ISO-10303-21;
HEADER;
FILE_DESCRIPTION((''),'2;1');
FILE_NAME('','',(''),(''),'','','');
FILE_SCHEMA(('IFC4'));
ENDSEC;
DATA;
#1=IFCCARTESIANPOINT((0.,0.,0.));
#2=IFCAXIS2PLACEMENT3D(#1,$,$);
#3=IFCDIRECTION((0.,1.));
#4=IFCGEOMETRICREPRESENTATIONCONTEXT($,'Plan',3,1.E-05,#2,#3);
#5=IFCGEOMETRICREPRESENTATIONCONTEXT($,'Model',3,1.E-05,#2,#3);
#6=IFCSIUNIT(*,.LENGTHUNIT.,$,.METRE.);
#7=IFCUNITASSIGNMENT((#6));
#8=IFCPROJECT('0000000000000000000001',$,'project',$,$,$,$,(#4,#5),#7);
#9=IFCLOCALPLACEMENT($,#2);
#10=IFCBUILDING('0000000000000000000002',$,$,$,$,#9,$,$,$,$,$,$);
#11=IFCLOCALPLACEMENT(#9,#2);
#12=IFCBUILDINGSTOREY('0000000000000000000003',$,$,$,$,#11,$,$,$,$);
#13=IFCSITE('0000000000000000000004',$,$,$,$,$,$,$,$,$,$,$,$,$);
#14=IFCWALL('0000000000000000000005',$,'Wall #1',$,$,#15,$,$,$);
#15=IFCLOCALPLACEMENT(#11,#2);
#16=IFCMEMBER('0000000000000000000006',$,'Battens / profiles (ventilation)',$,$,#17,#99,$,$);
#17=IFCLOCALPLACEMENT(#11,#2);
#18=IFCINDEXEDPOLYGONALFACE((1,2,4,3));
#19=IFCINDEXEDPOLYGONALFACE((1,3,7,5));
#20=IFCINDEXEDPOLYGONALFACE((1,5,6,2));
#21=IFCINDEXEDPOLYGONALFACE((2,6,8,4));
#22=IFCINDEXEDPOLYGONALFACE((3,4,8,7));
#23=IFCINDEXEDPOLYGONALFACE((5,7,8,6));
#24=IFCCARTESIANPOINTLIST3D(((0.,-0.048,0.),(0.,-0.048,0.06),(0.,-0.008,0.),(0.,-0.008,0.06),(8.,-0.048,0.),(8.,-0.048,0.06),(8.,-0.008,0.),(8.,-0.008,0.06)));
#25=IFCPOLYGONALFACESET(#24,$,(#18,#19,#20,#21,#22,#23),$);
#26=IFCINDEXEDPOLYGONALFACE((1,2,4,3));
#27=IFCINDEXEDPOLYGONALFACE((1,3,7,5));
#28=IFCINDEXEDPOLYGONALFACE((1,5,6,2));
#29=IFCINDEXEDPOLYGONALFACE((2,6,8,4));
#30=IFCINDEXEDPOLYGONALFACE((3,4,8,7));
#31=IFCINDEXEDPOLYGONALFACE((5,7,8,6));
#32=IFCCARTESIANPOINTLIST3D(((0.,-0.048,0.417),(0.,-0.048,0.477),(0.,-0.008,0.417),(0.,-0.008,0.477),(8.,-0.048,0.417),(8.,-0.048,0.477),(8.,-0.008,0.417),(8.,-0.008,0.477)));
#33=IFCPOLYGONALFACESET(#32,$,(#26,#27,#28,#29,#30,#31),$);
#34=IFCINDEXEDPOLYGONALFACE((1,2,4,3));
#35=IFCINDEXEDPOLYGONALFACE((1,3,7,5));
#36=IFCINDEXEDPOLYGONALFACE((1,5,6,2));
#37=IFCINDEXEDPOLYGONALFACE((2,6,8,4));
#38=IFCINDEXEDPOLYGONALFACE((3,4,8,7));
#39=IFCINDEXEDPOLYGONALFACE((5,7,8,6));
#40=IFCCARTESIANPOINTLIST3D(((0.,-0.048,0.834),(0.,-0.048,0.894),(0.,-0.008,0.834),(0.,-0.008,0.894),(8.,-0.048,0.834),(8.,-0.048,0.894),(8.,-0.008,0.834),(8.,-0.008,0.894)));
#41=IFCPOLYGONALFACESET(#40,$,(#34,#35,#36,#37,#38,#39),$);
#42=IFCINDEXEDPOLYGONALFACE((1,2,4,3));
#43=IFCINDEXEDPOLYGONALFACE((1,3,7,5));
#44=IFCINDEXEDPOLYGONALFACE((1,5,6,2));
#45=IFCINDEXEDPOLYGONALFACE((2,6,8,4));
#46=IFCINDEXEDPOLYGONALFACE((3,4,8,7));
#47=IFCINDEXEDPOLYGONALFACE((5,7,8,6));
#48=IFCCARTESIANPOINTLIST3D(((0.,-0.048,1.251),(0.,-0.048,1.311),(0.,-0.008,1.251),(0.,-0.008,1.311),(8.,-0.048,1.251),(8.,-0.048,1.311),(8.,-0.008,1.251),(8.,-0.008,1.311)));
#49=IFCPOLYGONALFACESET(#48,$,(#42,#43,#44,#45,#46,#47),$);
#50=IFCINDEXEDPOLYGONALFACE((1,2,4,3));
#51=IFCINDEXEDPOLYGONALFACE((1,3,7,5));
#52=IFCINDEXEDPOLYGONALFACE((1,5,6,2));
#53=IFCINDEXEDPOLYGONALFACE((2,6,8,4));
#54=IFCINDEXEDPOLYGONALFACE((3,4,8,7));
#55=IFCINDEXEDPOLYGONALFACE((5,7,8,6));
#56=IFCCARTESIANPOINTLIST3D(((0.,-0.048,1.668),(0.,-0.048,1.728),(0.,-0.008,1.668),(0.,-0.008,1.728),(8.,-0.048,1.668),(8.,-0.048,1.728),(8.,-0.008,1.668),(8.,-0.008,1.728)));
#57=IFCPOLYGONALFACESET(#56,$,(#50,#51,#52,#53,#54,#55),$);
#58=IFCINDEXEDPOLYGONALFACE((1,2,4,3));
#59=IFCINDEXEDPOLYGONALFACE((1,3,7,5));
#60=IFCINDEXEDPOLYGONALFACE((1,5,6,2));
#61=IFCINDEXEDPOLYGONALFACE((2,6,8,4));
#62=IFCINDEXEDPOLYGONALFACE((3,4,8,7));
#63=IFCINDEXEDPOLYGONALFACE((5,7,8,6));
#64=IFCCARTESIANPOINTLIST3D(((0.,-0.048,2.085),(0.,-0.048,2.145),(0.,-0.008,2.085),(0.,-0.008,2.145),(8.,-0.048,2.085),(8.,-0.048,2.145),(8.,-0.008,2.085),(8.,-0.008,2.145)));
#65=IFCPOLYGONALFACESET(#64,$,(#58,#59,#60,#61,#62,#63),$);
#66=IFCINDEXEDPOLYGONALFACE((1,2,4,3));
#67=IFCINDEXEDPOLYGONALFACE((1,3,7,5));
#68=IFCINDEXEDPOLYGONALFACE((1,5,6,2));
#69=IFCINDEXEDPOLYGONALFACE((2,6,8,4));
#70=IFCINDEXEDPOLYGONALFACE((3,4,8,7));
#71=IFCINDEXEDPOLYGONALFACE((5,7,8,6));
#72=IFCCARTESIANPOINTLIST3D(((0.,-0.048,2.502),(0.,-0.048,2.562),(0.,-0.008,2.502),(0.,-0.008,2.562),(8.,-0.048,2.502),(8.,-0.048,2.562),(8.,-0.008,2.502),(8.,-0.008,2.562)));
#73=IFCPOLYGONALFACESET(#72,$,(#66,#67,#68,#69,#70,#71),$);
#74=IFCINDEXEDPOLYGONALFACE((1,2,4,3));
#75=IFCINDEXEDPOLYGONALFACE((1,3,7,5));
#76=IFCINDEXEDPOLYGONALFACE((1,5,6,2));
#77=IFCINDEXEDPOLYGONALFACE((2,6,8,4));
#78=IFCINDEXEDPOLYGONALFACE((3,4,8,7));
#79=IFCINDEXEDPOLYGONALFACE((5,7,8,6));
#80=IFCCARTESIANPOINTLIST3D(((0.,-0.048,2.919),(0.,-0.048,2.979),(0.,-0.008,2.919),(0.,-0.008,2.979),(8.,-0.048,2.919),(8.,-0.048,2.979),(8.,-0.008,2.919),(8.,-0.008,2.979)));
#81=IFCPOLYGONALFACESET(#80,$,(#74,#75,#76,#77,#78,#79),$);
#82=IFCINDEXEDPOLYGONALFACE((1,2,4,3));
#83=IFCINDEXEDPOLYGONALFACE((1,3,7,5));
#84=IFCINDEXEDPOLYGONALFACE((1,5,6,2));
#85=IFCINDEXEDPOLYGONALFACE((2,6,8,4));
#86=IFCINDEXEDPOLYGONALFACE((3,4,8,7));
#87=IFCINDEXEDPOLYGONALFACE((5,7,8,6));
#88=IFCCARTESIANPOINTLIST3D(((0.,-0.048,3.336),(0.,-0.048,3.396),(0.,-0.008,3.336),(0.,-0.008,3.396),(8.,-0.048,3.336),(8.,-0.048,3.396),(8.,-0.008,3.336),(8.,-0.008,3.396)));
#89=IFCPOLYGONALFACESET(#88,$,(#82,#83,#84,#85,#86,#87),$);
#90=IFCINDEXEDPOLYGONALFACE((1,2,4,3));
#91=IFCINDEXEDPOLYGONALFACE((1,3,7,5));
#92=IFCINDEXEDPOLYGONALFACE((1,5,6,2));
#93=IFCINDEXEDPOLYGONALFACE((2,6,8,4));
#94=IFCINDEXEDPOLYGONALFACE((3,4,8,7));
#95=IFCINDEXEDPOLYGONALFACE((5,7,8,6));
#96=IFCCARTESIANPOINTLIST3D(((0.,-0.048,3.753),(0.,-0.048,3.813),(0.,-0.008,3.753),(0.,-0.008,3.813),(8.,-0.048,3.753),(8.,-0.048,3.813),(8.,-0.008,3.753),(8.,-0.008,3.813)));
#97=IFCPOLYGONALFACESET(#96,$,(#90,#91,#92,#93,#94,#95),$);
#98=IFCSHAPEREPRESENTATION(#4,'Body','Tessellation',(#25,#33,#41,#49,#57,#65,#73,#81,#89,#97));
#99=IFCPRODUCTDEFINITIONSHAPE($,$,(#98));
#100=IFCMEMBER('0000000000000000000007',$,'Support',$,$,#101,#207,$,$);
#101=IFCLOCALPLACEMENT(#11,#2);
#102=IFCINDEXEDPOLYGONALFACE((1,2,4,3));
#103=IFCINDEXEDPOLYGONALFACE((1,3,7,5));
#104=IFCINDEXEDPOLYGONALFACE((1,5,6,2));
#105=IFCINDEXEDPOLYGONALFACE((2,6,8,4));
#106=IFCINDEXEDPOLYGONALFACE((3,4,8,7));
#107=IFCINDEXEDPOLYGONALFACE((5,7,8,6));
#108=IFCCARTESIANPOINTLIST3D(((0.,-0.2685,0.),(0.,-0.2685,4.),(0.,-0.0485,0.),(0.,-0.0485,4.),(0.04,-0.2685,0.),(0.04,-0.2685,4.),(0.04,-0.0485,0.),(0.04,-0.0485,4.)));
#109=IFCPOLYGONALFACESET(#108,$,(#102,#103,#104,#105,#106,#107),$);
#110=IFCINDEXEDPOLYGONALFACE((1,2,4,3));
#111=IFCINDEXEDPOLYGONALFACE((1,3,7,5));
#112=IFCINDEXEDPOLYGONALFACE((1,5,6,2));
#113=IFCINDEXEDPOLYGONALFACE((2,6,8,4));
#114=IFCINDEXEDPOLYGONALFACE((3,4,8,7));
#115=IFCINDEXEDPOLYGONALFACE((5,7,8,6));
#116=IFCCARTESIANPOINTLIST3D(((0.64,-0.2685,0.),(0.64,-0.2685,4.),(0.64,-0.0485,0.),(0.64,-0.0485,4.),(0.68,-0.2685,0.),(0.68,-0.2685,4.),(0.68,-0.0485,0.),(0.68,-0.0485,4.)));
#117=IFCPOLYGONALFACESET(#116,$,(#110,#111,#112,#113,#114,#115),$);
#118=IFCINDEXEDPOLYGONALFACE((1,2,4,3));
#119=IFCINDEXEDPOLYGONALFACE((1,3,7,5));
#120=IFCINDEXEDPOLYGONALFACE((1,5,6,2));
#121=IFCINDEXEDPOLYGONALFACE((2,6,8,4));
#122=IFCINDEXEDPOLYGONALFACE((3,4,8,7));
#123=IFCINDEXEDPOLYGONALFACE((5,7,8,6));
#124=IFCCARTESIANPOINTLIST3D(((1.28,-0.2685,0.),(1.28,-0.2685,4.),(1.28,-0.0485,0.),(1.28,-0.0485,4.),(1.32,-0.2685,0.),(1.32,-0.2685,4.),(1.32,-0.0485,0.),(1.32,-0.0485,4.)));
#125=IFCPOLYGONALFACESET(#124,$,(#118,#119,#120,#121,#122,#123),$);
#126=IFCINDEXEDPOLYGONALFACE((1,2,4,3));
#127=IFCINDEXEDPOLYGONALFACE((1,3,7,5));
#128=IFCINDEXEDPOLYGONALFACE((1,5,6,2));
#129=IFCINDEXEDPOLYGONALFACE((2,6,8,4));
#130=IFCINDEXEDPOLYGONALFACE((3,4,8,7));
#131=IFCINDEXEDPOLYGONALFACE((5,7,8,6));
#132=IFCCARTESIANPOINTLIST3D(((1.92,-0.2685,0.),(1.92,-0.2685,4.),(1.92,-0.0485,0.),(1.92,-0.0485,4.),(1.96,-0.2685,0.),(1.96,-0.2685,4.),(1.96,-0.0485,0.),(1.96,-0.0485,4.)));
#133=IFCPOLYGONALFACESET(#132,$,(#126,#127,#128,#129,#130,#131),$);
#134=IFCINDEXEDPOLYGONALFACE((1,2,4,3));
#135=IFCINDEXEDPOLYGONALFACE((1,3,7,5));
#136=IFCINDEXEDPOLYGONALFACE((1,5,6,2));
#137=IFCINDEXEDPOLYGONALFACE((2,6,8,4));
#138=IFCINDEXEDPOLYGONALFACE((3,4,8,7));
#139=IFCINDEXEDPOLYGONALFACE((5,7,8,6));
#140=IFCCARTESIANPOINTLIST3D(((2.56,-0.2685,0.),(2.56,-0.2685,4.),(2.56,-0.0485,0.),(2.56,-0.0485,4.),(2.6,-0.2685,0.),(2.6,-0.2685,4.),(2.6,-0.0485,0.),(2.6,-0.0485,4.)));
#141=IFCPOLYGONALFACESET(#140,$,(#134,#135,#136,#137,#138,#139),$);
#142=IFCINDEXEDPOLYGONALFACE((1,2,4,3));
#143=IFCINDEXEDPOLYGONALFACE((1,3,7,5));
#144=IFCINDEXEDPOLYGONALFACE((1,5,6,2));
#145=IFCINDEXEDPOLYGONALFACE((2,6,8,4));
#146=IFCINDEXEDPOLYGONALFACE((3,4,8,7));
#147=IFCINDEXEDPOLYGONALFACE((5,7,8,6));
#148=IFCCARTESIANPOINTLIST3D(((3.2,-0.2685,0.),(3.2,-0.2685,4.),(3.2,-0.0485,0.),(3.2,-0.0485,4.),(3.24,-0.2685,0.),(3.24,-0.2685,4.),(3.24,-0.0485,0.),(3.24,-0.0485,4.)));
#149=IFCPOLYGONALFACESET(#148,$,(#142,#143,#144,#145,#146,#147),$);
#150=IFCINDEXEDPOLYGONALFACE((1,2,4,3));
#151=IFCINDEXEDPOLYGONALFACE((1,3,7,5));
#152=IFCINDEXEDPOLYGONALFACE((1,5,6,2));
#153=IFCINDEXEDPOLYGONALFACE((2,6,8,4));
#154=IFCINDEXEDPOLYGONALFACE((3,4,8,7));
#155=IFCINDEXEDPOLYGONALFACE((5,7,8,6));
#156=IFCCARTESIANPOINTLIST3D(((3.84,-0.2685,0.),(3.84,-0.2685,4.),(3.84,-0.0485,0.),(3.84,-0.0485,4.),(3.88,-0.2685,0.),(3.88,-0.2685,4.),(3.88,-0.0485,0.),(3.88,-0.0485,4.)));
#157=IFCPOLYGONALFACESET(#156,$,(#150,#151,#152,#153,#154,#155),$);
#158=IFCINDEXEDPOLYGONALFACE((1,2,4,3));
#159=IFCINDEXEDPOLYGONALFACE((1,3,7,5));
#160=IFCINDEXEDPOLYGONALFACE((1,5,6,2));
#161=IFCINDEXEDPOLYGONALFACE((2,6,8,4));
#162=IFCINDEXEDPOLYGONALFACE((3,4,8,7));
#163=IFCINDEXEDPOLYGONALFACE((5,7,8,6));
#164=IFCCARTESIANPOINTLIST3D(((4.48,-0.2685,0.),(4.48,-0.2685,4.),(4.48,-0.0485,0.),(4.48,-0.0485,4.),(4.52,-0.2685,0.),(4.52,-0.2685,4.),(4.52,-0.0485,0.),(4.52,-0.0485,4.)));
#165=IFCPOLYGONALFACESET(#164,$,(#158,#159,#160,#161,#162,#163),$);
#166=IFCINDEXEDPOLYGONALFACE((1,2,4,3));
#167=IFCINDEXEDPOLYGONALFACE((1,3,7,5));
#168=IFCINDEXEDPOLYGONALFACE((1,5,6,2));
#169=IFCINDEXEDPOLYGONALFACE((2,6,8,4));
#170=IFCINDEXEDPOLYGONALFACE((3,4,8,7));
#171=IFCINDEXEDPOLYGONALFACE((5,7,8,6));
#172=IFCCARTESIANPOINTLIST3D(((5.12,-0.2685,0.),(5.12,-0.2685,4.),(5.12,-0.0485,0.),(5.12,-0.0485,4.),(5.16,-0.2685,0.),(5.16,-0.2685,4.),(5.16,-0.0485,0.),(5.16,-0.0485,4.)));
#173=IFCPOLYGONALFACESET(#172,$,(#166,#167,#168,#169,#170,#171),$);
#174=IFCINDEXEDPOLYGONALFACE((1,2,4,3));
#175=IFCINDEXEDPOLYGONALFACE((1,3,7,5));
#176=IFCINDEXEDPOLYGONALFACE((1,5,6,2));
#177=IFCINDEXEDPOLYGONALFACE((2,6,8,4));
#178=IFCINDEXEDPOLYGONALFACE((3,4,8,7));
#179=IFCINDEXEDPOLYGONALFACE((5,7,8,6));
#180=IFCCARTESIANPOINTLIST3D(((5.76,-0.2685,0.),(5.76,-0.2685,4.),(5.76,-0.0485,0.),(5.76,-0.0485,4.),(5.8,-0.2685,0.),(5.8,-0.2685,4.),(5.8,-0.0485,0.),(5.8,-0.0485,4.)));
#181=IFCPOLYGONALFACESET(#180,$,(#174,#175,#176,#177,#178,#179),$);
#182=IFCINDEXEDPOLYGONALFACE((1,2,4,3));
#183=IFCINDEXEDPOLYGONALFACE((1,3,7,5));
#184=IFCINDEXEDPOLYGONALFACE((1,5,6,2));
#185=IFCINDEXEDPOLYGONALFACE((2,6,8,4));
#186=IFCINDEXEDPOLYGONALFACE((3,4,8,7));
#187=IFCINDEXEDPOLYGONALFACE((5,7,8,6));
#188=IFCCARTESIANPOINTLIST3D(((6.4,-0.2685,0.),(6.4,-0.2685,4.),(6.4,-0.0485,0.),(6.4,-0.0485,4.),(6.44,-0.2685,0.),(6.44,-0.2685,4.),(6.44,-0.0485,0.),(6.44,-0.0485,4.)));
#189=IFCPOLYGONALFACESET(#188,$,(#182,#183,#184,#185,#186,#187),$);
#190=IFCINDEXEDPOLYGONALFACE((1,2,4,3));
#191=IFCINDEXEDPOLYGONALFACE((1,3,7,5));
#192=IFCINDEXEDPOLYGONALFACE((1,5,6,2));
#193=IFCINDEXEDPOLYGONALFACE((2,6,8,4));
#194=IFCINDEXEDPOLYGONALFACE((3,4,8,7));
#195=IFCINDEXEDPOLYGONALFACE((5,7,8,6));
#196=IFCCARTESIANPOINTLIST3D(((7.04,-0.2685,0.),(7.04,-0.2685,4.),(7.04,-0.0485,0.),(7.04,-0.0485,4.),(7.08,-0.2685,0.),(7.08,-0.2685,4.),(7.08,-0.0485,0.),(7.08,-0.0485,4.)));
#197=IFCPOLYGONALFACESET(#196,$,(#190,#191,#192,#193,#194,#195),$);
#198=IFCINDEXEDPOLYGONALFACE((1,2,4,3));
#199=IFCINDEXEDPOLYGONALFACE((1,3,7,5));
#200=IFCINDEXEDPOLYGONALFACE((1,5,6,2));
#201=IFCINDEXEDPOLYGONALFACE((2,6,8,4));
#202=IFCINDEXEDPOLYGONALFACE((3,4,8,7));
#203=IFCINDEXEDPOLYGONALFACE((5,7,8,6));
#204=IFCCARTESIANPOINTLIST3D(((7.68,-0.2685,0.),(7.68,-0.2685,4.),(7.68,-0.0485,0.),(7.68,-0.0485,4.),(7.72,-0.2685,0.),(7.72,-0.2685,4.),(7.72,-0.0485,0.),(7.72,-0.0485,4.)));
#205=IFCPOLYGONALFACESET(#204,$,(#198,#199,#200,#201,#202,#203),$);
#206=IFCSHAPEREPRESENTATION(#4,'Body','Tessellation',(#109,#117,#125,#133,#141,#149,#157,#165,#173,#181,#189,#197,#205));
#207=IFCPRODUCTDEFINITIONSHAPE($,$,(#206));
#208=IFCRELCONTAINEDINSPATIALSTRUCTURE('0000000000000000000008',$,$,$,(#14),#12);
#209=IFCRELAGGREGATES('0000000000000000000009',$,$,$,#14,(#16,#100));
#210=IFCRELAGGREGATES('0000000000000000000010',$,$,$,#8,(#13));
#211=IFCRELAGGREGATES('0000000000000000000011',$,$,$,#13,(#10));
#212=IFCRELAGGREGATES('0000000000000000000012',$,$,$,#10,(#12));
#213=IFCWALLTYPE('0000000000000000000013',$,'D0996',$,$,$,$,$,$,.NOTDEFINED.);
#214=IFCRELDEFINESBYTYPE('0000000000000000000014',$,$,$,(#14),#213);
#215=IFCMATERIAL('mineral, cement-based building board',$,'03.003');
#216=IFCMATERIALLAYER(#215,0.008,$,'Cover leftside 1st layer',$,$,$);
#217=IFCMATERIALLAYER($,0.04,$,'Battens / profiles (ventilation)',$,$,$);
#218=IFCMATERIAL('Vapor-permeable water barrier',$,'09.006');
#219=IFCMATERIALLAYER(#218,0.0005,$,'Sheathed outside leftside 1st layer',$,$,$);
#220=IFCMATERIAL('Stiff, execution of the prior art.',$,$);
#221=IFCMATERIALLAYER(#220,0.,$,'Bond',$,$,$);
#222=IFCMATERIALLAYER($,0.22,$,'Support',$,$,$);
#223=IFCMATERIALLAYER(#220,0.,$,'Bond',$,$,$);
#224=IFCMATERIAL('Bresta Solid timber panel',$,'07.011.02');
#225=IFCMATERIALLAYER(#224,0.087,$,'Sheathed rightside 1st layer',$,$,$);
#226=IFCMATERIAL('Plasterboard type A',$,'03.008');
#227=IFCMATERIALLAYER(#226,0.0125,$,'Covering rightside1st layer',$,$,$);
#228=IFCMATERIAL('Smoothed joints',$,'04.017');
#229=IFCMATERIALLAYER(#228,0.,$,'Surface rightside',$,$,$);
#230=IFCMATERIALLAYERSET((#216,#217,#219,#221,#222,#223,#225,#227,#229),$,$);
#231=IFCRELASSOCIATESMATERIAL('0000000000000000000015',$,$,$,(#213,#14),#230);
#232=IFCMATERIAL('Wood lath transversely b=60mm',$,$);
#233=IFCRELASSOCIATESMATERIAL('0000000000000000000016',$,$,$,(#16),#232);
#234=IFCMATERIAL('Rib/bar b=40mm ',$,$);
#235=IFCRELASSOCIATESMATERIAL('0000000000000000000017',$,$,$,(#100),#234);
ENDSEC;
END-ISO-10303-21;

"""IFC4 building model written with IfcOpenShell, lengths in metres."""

from ifc_helpers import new_model, si_unit, direction, frame, frame_2d, origin, place, context, project, spatial, rectangle, extrude, material, layer, layer_set, type_object, element, aggregate, save


model = new_model("IFC4")

# Units and contexts
plan_context = context("Plan", 3, precision=1e-05, world=origin(), true_north=direction((0.0, 1.0)))
model_context = context("Model", 3, precision=1e-05, world=origin(), true_north=direction((0.0, 1.0)))
ifc_project = project(units=[si_unit("LENGTHUNIT", "METRE")], contexts=[plan_context, model_context])

# Site, building, storey
site = spatial("IfcSite", under=ifc_project)
building_placement = place(None, origin())
building = spatial("IfcBuilding", under=site, at=building_placement)
storey_placement = place(building_placement, origin())
storey = spatial("IfcBuildingStorey", under=building, at=storey_placement)

# Wall, members
ifc_material_1 = material(Name="mineral, cement-based building board", Category="03.003")
ifc_layer_1 = layer(ifc_material_1, 0.008, Name="Cover leftside 1st layer")
ifc_layer_2 = layer(None, 0.04, Name="Battens / profiles (ventilation)")
ifc_material_2 = material(Name="Vapor-permeable water barrier", Category="09.006")
ifc_layer_3 = layer(ifc_material_2, 0.0005, Name="Sheathed outside leftside 1st layer")
ifc_material_3 = material(Name="Stiff, execution of the prior art.")
ifc_layer_4 = layer(ifc_material_3, 0.0, Name="Bond")
ifc_layer_5 = layer(None, 0.22, Name="Support")
ifc_layer_6 = layer(ifc_material_3, 0.0, Name="Bond")
ifc_material_4 = material(Name="Bresta Solid timber panel", Category="07.011.02")
ifc_layer_7 = layer(ifc_material_4, 0.087, Name="Sheathed rightside 1st layer")
ifc_material_5 = material(Name="Plasterboard type A", Category="03.008")
ifc_layer_8 = layer(ifc_material_5, 0.0125, Name="Covering rightside1st layer")
ifc_material_6 = material(Name="Smoothed joints", Category="04.017")
ifc_layer_9 = layer(ifc_material_6, 0.0, Name="Surface rightside")
ifc_layer_set = layer_set([ifc_layer_1, ifc_layer_2, ifc_layer_3, ifc_layer_4, ifc_layer_5, ifc_layer_6, ifc_layer_7, ifc_layer_8, ifc_layer_9])
wall_type = type_object("IfcWallType", Name="D0996", PredefinedType="NOTDEFINED", material=ifc_layer_set)
wall_placement = place(None, frame((0.0, 0.0, 0.0), z_axis=(0.0, -1.0, 0.0), x_axis=(1.0, 0.0, 0.0)))
wall = element("IfcWall", 1, at=wall_placement, inside=storey, type_object=wall_type, material=ifc_layer_set, Name="Wall #1")
ifc_material_7 = material(Name="Wood lath transversely b=60mm")
member_1_placement = place(wall_placement, origin())
member_1 = element("IfcMember", 2, at=member_1_placement, material=ifc_material_7, Name="Battens / profiles (ventilation)", context=plan_context, shape_type="SweptSolid", body=[
    extrude(rectangle(XDim=0.06, YDim=0.04, at=frame_2d((0.03, 0.02), x_axis=(1.0, 0.0))), frame((0.0, 0.0, 0.008), z_axis=(1.0, 0.0, 0.0), x_axis=(0.0, 1.0, 0.0)), (0.0, 0.0, 1.0), 8.0),
    extrude(rectangle(XDim=0.06, YDim=0.04, at=frame_2d((0.03, 0.02), x_axis=(1.0, 0.0))), frame((0.0, 0.417, 0.008), z_axis=(1.0, 0.0, 0.0), x_axis=(0.0, 1.0, 0.0)), (0.0, 0.0, 1.0), 8.0),
    extrude(rectangle(XDim=0.06, YDim=0.04, at=frame_2d((0.03, 0.02), x_axis=(1.0, 0.0))), frame((0.0, 0.834, 0.008), z_axis=(1.0, 0.0, 0.0), x_axis=(0.0, 1.0, 0.0)), (0.0, 0.0, 1.0), 8.0),
    extrude(rectangle(XDim=0.06, YDim=0.04, at=frame_2d((0.03, 0.02), x_axis=(1.0, 0.0))), frame((0.0, 1.251, 0.008), z_axis=(1.0, 0.0, 0.0), x_axis=(0.0, 1.0, 0.0)), (0.0, 0.0, 1.0), 8.0),
    extrude(rectangle(XDim=0.06, YDim=0.04, at=frame_2d((0.03, 0.02), x_axis=(1.0, 0.0))), frame((0.0, 1.668, 0.008), z_axis=(1.0, 0.0, 0.0), x_axis=(0.0, 1.0, 0.0)), (0.0, 0.0, 1.0), 8.0),
    extrude(rectangle(XDim=0.06, YDim=0.04, at=frame_2d((0.03, 0.02), x_axis=(1.0, 0.0))), frame((0.0, 2.085, 0.008), z_axis=(1.0, 0.0, 0.0), x_axis=(0.0, 1.0, 0.0)), (0.0, 0.0, 1.0), 8.0),
    extrude(rectangle(XDim=0.06, YDim=0.04, at=frame_2d((0.03, 0.02), x_axis=(1.0, 0.0))), frame((0.0, 2.502, 0.008), z_axis=(1.0, 0.0, 0.0), x_axis=(0.0, 1.0, 0.0)), (0.0, 0.0, 1.0), 8.0),
    extrude(rectangle(XDim=0.06, YDim=0.04, at=frame_2d((0.03, 0.02), x_axis=(1.0, 0.0))), frame((0.0, 2.919, 0.008), z_axis=(1.0, 0.0, 0.0), x_axis=(0.0, 1.0, 0.0)), (0.0, 0.0, 1.0), 8.0),
    extrude(rectangle(XDim=0.06, YDim=0.04, at=frame_2d((0.03, 0.02), x_axis=(1.0, 0.0))), frame((0.0, 3.336, 0.008), z_axis=(1.0, 0.0, 0.0), x_axis=(0.0, 1.0, 0.0)), (0.0, 0.0, 1.0), 8.0),
    extrude(rectangle(XDim=0.06, YDim=0.04, at=frame_2d((0.03, 0.02), x_axis=(1.0, 0.0))), frame((0.0, 3.753, 0.008), z_axis=(1.0, 0.0, 0.0), x_axis=(0.0, 1.0, 0.0)), (0.0, 0.0, 1.0), 8.0),
])
ifc_material_8 = material(Name="Rib/bar b=40mm ")
member_2_placement = place(wall_placement, origin())
member_2 = element("IfcMember", 3, at=member_2_placement, material=ifc_material_8, Name="Support", context=plan_context, shape_type="SweptSolid", body=[
    extrude(rectangle(XDim=0.04, YDim=0.22, at=frame_2d((0.02, 0.11), x_axis=(1.0, 0.0))), frame((0.0, 4.0, 0.0485), z_axis=(0.0, -1.0, 0.0), x_axis=(1.0, 0.0, 0.0)), (0.0, 0.0, 1.0), 4.0),
    extrude(rectangle(XDim=0.04, YDim=0.22, at=frame_2d((0.02, 0.11), x_axis=(1.0, 0.0))), frame((0.64, 4.0, 0.0485), z_axis=(0.0, -1.0, 0.0), x_axis=(1.0, 0.0, 0.0)), (0.0, 0.0, 1.0), 4.0),
    extrude(rectangle(XDim=0.04, YDim=0.22, at=frame_2d((0.02, 0.11), x_axis=(1.0, 0.0))), frame((1.28, 4.0, 0.0485), z_axis=(0.0, -1.0, 0.0), x_axis=(1.0, 0.0, 0.0)), (0.0, 0.0, 1.0), 4.0),
    extrude(rectangle(XDim=0.04, YDim=0.22, at=frame_2d((0.02, 0.11), x_axis=(1.0, 0.0))), frame((1.92, 4.0, 0.0485), z_axis=(0.0, -1.0, 0.0), x_axis=(1.0, 0.0, 0.0)), (0.0, 0.0, 1.0), 4.0),
    extrude(rectangle(XDim=0.04, YDim=0.22, at=frame_2d((0.02, 0.11), x_axis=(1.0, 0.0))), frame((2.56, 4.0, 0.0485), z_axis=(0.0, -1.0, 0.0), x_axis=(1.0, 0.0, 0.0)), (0.0, 0.0, 1.0), 4.0),
    extrude(rectangle(XDim=0.04, YDim=0.22, at=frame_2d((0.02, 0.11), x_axis=(1.0, 0.0))), frame((3.2, 4.0, 0.0485), z_axis=(0.0, -1.0, 0.0), x_axis=(1.0, 0.0, 0.0)), (0.0, 0.0, 1.0), 4.0),
    extrude(rectangle(XDim=0.04, YDim=0.22, at=frame_2d((0.02, 0.11), x_axis=(1.0, 0.0))), frame((3.84, 4.0, 0.0485), z_axis=(0.0, -1.0, 0.0), x_axis=(1.0, 0.0, 0.0)), (0.0, 0.0, 1.0), 4.0),
    extrude(rectangle(XDim=0.04, YDim=0.22, at=frame_2d((0.02, 0.11), x_axis=(1.0, 0.0))), frame((4.48, 4.0, 0.0485), z_axis=(0.0, -1.0, 0.0), x_axis=(1.0, 0.0, 0.0)), (0.0, 0.0, 1.0), 4.0),
    extrude(rectangle(XDim=0.04, YDim=0.22, at=frame_2d((0.02, 0.11), x_axis=(1.0, 0.0))), frame((5.12, 4.0, 0.0485), z_axis=(0.0, -1.0, 0.0), x_axis=(1.0, 0.0, 0.0)), (0.0, 0.0, 1.0), 4.0),
    extrude(rectangle(XDim=0.04, YDim=0.22, at=frame_2d((0.02, 0.11), x_axis=(1.0, 0.0))), frame((5.76, 4.0, 0.0485), z_axis=(0.0, -1.0, 0.0), x_axis=(1.0, 0.0, 0.0)), (0.0, 0.0, 1.0), 4.0),
    extrude(rectangle(XDim=0.04, YDim=0.22, at=frame_2d((0.02, 0.11), x_axis=(1.0, 0.0))), frame((6.4, 4.0, 0.0485), z_axis=(0.0, -1.0, 0.0), x_axis=(1.0, 0.0, 0.0)), (0.0, 0.0, 1.0), 4.0),
    extrude(rectangle(XDim=0.04, YDim=0.22, at=frame_2d((0.02, 0.11), x_axis=(1.0, 0.0))), frame((7.04, 4.0, 0.0485), z_axis=(0.0, -1.0, 0.0), x_axis=(1.0, 0.0, 0.0)), (0.0, 0.0, 1.0), 4.0),
    extrude(rectangle(XDim=0.04, YDim=0.22, at=frame_2d((0.02, 0.11), x_axis=(1.0, 0.0))), frame((7.68, 4.0, 0.0485), z_axis=(0.0, -1.0, 0.0), x_axis=(1.0, 0.0, 0.0)), (0.0, 0.0, 1.0), 4.0),
])
aggregate(wall, [member_1, member_2])

save(model, "model.ifc")
